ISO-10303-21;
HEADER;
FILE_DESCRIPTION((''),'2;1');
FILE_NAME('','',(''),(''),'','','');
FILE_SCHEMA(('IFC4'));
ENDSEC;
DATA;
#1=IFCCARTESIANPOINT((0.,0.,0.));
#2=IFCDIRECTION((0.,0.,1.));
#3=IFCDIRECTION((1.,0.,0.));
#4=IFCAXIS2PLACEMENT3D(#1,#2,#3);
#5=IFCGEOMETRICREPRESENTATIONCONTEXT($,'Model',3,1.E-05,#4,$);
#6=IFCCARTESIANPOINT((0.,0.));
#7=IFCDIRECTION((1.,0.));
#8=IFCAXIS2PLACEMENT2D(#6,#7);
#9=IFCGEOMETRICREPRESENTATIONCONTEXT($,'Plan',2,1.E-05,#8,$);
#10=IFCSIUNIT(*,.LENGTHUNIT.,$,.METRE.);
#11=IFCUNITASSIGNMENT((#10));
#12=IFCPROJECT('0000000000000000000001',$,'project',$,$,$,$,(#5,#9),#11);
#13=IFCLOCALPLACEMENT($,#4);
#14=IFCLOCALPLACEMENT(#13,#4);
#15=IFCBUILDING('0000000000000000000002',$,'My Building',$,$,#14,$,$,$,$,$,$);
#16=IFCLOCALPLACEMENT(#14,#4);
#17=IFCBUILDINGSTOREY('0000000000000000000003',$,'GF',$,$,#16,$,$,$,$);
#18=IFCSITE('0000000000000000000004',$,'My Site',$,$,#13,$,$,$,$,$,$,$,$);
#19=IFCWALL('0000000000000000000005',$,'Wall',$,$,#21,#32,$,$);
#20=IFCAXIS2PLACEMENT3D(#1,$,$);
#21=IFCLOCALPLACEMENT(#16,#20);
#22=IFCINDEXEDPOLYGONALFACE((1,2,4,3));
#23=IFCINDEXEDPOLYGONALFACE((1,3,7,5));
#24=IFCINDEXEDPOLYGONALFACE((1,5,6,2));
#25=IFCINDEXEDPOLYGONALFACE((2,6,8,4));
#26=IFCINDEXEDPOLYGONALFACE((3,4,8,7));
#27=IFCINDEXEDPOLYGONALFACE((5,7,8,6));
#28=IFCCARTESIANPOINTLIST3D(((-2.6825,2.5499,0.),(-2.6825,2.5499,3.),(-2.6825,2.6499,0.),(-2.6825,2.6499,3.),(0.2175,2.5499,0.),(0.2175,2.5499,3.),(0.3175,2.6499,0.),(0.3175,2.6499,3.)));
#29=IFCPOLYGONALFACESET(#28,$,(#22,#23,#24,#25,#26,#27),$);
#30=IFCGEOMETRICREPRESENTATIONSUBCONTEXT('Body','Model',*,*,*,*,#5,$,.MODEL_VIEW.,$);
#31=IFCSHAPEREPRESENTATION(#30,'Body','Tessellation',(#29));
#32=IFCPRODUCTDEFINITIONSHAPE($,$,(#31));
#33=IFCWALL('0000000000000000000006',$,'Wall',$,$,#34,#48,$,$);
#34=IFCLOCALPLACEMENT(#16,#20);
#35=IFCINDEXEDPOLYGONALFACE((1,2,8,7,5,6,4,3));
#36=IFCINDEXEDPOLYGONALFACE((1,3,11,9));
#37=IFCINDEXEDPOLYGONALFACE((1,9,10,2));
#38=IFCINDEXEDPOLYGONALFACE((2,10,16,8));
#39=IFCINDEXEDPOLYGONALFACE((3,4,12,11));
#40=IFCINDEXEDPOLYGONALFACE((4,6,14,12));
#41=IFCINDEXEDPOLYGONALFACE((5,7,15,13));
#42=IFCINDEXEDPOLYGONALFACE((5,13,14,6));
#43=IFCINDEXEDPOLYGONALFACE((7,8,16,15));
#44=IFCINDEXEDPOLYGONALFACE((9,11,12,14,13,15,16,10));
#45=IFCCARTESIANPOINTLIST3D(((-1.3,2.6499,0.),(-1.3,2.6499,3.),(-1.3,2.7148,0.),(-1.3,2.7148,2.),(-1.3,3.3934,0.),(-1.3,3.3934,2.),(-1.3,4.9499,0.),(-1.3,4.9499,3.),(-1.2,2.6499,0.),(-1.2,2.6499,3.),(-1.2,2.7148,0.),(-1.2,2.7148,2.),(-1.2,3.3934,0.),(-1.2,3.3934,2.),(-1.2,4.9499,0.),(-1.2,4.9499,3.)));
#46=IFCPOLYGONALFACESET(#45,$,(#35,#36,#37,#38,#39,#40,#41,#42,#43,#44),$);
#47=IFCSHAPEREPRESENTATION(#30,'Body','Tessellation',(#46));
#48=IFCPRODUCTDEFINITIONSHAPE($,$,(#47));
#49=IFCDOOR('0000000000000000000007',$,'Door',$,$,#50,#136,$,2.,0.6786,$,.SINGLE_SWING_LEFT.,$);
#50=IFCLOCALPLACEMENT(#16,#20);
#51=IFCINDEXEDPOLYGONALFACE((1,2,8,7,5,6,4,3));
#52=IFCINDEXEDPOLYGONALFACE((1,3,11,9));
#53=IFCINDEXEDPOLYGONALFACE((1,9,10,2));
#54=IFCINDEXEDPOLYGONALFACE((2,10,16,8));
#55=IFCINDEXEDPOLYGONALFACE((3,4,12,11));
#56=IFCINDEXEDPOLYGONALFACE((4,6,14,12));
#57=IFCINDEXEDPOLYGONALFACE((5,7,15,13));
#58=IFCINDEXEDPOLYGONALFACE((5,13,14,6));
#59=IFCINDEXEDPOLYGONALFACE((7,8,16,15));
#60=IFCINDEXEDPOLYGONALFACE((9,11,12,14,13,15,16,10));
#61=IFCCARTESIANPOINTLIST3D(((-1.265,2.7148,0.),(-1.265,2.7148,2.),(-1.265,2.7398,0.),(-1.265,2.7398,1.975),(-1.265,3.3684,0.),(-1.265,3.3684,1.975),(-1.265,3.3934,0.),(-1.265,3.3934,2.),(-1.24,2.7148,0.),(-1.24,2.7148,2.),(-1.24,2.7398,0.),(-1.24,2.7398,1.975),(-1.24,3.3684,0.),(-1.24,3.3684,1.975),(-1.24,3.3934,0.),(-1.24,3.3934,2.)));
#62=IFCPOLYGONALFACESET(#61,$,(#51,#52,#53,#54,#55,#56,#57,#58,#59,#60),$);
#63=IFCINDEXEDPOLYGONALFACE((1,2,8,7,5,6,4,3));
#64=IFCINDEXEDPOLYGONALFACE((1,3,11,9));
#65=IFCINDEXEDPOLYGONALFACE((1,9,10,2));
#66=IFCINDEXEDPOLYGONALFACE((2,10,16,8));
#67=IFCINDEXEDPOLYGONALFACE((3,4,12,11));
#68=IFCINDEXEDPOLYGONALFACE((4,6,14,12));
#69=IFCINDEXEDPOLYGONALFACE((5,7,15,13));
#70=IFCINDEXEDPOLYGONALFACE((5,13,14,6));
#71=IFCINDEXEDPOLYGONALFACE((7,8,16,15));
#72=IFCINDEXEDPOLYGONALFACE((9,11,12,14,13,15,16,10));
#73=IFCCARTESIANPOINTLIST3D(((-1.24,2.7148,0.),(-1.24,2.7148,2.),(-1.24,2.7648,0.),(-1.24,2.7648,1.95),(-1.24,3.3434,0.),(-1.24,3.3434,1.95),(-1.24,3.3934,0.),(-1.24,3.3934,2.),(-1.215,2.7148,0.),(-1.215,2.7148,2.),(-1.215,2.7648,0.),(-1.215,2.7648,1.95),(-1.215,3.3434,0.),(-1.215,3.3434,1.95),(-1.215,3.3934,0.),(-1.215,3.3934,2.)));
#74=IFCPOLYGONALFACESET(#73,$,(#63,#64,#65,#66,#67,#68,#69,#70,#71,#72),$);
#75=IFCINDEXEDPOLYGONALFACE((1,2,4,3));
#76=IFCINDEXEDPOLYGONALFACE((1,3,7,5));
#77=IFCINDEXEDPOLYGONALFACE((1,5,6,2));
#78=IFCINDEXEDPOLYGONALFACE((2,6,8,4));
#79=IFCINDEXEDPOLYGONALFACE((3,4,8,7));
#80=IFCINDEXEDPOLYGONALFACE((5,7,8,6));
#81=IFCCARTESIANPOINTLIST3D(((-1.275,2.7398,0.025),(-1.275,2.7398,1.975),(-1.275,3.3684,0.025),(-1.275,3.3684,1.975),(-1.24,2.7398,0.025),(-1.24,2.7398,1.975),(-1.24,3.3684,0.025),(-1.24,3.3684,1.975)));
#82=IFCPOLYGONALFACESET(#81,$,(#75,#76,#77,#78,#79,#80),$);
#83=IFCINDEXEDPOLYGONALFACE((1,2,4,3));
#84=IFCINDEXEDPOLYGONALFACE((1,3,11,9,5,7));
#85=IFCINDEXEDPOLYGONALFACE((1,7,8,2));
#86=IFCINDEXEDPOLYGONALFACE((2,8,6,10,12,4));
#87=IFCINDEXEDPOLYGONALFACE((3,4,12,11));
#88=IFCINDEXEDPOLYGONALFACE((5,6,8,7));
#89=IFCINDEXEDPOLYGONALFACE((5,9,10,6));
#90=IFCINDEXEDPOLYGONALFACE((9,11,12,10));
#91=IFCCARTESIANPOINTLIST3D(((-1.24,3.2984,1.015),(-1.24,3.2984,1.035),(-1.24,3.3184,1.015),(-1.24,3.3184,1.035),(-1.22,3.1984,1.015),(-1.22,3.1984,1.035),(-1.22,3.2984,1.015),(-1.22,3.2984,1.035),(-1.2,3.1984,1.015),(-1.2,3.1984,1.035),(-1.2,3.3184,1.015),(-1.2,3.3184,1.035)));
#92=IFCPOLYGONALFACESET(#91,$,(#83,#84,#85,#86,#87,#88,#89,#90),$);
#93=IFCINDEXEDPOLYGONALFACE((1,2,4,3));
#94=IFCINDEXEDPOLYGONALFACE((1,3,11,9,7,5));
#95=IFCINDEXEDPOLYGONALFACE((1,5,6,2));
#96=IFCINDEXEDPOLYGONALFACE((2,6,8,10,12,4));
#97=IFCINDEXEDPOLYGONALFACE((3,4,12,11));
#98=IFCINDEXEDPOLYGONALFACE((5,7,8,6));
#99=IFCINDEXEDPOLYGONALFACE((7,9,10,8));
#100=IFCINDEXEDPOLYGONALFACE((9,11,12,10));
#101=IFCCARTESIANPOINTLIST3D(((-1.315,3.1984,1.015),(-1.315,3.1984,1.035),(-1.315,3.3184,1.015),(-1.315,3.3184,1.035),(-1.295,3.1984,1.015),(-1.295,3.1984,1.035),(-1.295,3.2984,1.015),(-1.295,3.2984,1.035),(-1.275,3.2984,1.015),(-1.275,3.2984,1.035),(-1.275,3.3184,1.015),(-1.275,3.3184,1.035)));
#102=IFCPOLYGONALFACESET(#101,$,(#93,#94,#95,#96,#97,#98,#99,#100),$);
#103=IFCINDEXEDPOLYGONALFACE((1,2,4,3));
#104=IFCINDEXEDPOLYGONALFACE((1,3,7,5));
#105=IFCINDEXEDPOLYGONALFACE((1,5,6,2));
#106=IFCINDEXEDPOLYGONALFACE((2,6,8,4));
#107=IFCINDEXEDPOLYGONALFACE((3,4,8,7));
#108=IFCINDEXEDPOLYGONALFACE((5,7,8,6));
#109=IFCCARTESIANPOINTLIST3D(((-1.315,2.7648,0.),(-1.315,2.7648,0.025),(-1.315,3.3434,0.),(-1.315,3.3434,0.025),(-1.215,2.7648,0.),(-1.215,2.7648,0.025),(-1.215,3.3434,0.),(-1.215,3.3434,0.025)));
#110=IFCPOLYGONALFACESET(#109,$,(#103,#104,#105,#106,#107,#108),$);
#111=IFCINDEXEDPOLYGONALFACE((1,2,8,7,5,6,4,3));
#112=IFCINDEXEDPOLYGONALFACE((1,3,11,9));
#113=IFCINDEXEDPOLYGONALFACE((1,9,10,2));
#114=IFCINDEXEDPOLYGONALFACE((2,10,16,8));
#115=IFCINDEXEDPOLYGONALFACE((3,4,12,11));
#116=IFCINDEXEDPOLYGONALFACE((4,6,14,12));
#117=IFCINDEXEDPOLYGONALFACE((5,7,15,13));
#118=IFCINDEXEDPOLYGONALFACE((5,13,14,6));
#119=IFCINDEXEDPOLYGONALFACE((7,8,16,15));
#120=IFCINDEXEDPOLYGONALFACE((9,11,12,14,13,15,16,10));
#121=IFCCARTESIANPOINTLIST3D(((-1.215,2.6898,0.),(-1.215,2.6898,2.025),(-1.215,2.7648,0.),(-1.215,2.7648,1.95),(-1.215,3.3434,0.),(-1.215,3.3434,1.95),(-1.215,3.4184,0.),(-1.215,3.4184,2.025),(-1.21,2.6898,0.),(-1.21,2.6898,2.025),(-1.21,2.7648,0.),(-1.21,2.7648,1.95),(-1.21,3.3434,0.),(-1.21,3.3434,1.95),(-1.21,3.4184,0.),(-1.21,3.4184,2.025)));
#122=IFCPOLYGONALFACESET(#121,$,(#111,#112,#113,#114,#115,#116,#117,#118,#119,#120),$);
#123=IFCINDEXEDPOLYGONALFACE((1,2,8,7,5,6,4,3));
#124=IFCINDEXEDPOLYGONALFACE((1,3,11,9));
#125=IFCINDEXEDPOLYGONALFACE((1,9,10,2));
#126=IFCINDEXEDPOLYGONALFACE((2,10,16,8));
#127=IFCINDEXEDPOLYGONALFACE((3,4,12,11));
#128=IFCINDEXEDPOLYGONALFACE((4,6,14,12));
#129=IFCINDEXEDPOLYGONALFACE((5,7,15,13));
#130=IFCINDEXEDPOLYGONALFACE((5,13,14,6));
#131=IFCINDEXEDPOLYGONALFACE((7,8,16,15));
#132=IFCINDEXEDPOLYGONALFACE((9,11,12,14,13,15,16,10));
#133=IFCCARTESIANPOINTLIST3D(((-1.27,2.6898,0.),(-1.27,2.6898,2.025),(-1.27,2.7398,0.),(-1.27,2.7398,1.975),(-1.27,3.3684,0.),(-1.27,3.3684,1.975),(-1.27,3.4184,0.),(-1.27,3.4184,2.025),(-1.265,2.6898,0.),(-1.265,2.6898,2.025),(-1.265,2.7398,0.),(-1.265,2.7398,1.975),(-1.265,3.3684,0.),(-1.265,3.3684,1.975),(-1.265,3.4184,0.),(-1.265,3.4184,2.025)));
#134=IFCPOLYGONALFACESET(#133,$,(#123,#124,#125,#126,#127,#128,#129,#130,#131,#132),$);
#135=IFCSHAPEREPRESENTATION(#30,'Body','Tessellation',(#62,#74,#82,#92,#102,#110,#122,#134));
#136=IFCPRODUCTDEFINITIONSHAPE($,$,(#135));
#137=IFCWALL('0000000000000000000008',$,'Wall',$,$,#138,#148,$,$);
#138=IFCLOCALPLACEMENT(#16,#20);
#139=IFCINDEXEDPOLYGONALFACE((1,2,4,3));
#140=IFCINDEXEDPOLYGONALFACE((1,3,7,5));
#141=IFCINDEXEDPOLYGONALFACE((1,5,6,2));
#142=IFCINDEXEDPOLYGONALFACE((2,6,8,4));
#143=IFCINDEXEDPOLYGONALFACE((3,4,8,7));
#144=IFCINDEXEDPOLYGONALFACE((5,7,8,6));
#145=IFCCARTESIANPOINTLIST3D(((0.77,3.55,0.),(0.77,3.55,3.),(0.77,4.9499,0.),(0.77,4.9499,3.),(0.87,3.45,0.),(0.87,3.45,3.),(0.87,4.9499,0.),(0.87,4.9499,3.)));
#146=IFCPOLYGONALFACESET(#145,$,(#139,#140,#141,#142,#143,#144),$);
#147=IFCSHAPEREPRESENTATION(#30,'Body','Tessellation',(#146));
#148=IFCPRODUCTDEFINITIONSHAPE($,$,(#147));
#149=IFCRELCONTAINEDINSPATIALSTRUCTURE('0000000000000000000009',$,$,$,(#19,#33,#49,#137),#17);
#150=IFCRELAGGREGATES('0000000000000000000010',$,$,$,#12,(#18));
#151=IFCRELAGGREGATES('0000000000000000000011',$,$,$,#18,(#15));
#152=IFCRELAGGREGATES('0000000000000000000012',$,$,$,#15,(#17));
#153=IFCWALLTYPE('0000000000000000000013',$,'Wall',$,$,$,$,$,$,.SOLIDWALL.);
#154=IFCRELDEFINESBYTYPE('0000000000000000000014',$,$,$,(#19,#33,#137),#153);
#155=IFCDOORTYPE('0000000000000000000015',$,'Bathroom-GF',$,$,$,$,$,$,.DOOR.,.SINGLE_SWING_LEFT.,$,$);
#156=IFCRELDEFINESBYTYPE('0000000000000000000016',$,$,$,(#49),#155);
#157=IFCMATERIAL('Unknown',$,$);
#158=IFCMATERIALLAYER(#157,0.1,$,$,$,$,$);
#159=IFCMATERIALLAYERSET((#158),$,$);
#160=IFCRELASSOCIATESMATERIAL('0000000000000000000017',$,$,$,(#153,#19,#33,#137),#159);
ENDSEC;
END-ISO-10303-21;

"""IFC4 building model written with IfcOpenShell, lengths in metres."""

from ifc_helpers import new_model, entity, si_unit, frame, origin_with_axes, origin_2d_with_axis, place, context, subcontext, project, spatial, line, indexed_curve, outline, extrude, shape, source, transform, mapped, material, layer, layer_set, layer_usage, type_object, type_shapes, element, fill, save


model = new_model("IFC4")

# Units and contexts
model_context = context("Model", 3, precision=1e-05, world=origin_with_axes())
plan_context = context("Plan", 2, precision=1e-05, world=origin_2d_with_axis())
body_context_1 = subcontext(model_context, "Body", "Model", "MODEL_VIEW")
body_context_2 = subcontext(plan_context, "Body", "Plan", "PLAN_VIEW")
ifc_project = project(units=[si_unit("LENGTHUNIT", "METRE")], contexts=[model_context, plan_context])

# Site, building, storey
site_placement = place(None, origin_with_axes())
site = spatial("IfcSite", under=ifc_project, at=site_placement, Name="My Site")
building_placement = place(site_placement, origin_with_axes())
building = spatial("IfcBuilding", under=site, at=building_placement, Name="My Building")
storey_placement = place(building_placement, origin_with_axes())
storey = spatial("IfcBuildingStorey", under=building, at=storey_placement, Name="GF")

# Shared definitions
ifc_material_1 = material(Name="Unknown")

# Shared definitions
ifc_layer_1 = layer(ifc_material_1, 0.1)
ifc_layer_set_1 = layer_set([ifc_layer_1])
wall_type = type_object("IfcWallType", Name="Wall", PredefinedType="SOLIDWALL", material=ifc_layer_set_1)

# Wall
ifc_layer_usage_1 = layer_usage(ifc_layer_set_1, "AXIS2", "POSITIVE", 0.0)
wall_1_placement = place(storey_placement, frame((0.3175, 2.6499, 0.0), z_axis=(0.0, 0.0, 1.0), x_axis=(-1.0, 0.0, 0.0)))
element("IfcWall", 1, at=wall_1_placement, inside=storey, type_object=wall_type, material=ifc_layer_usage_1, Name="Wall", context=body_context_1, shape_type="SweptSolid", body=[
    extrude(outline(indexed_curve([(0.0, 0.0), (0.1, 0.1), (3.0, 0.1), (3.0, 0.0)], segments=[line(1, 2, 3, 4, 1)])), origin_with_axes(), (0.0, 0.0, 1.0), 3.0),
])

# Wall, opening, door
ifc_layer_usage_2 = layer_usage(ifc_layer_set_1, "AXIS2", "POSITIVE", 0.0)
wall_2_placement = place(storey_placement, frame((-1.2, 2.6499, 0.0), z_axis=(0.0, 0.0, 1.0), x_axis=(0.0, 1.0, 0.0)))
wall_2 = element("IfcWall", 2, at=wall_2_placement, inside=storey, type_object=wall_type, material=ifc_layer_usage_2, Name="Wall", context=body_context_1, shape_type="SweptSolid", body=[
    extrude(outline(indexed_curve([(0.0, 0.0), (0.0, 0.1), (2.3, 0.1), (2.3, 0.0)], segments=[line(1, 2, 3, 4, 1)])), origin_with_axes(), (0.0, 0.0, 1.0), 3.0),
])
shared_shape_1 = source(origin_with_axes(), body_context_1, "Body", "SweptSolid", [
    extrude(outline(indexed_curve([(0.0, 0.0), (0.6786, 0.0), (0.6786, 2.0), (0.0, 2.0)], segments=[line(1, 2, 3, 4, 1)])), frame((0.0, -0.6, 0.0), z_axis=(0.0, -1.0, 0.0), x_axis=(1.0, 0.0, 0.0)), (0.0, 0.0, -1.0), 1.2),
])
opening_1_placement = place(wall_2_placement, frame((0.0649, 0.015, 0.0), z_axis=(0.0, 0.0, 1.0), x_axis=(1.0, 0.0, 0.0)))
opening_1 = element("IfcOpeningElement", 3, at=opening_1_placement, cuts=wall_2, PredefinedType="OPENING", context=body_context_1, shape_type="MappedRepresentation", body=[
    mapped(shared_shape_1, transform((0.0, 0.0, 0.0), x_axis=(1.0, 0.0, 0.0), y_axis=(0.0, 1.0, 0.0), z_axis=(0.0, 0.0, 1.0), scale=1.0)),
])
door_type_1 = type_object("IfcDoorType", Name="Bathroom-GF", OperationType="SINGLE_SWING_LEFT", PredefinedType="DOOR")
shared_shape_2 = source(origin_with_axes(), body_context_1, "Body", "SweptSolid", [
    extrude(outline(indexed_curve([(0.0, 0.0), (0.0, 2.0), (0.6786, 2.0), (0.6786, 0.0), (0.6536, 0.0), (0.6536, 1.975), (0.025, 1.975), (0.025, 0.0)], segments=[line(1, 2, 3, 4, 5, 6, 7, 8, 1)])), frame((0.0, 0.025, 0.0), z_axis=(0.0, -1.0, 0.0), x_axis=(1.0, 0.0, 0.0)), (0.0, 0.0, -1.0), 0.025),
    extrude(outline(indexed_curve([(0.0, 0.0), (0.0, 2.0), (0.6786, 2.0), (0.6786, 0.0), (0.6286, 0.0), (0.6286, 1.95), (0.05, 1.95), (0.05, 0.0)], segments=[line(1, 2, 3, 4, 5, 6, 7, 8, 1)])), frame((0.0, 0.0, 0.0), z_axis=(0.0, -1.0, 0.0), x_axis=(1.0, 0.0, 0.0)), (0.0, 0.0, -1.0), 0.025),
    extrude(outline(indexed_curve([(0.0, 0.0), (0.6286, 0.0), (0.6286, 0.035), (0.0, 0.035)], segments=[line(1, 2, 3, 4, 1)])), frame((0.025, 0.025, 0.025), z_axis=(0.0, 0.0, 1.0), x_axis=(1.0, 0.0, 0.0)), (0.0, 0.0, 1.0), 1.95),
    extrude(outline(indexed_curve([(0.0, 0.0), (0.0, -0.04), (-0.12, -0.04), (-0.12, -0.02), (-0.02, -0.02), (-0.02, 0.0)], segments=[line(1, 2, 3, 4, 5, 6, 1)])), frame((0.6036, 0.025, 1.015), z_axis=(0.0, 0.0, 1.0), x_axis=(1.0, 0.0, 0.0)), (0.0, 0.0, 1.0), 0.02),
    extrude(outline(indexed_curve([(0.0, 0.0), (0.0, 0.04), (-0.12, 0.04), (-0.12, 0.02), (-0.02, 0.02), (-0.02, 0.0)], segments=[line(1, 2, 3, 4, 5, 6, 1)])), frame((0.6036, 0.06, 1.015), z_axis=(0.0, 0.0, 1.0), x_axis=(1.0, 0.0, 0.0)), (0.0, 0.0, 1.0), 0.02),
    extrude(outline(indexed_curve([(0.0, 0.0), (0.5786, 0.0), (0.5786, 0.1), (0.0, 0.1)], segments=[line(1, 2, 3, 4, 1)])), frame((0.05, 0.0, 0.0), z_axis=(0.0, 0.0, 1.0), x_axis=(1.0, 0.0, 0.0)), (0.0, 0.0, 1.0), 0.025),
    extrude(outline(indexed_curve([(0.0, 0.0), (0.0, 2.025), (0.7286, 2.025), (0.7286, 0.0), (0.6536, 0.0), (0.6536, 1.95), (0.075, 1.95), (0.075, 0.0)], segments=[line(1, 2, 3, 4, 5, 6, 7, 8, 1)])), frame((-0.025, -0.005, 0.0), z_axis=(0.0, -1.0, 0.0), x_axis=(1.0, 0.0, 0.0)), (0.0, 0.0, -1.0), 0.005),
    extrude(outline(indexed_curve([(0.0, 0.0), (0.0, 2.025), (0.7286, 2.025), (0.7286, 0.0), (0.6786, 0.0), (0.6786, 1.975), (0.05, 1.975), (0.05, 0.0)], segments=[line(1, 2, 3, 4, 5, 6, 7, 8, 1)])), frame((-0.025, 0.05, 0.0), z_axis=(0.0, -1.0, 0.0), x_axis=(1.0, 0.0, 0.0)), (0.0, 0.0, -1.0), 0.005),
])
shared_shape_3 = source(origin_with_axes(), body_context_2, "Body", "Curve2D", [
    entity("IfcIndexedPolyCurve", entity("IfcCartesianPointList2D", [[0.0, 0.0], [0.0, 0.05], [0.025, 0.05], [0.025, 0.025], [0.05, 0.025], [0.05, 0.0]]), [entity("IfcLineIndex", [1, 2, 3, 4, 5, 6, 1])]),
    entity("IfcIndexedPolyCurve", entity("IfcCartesianPointList2D", [[0.6786, 0.0], [0.6786, 0.05], [0.6536, 0.05], [0.6536, 0.025], [0.6286, 0.025], [0.6286, 0.0]]), [entity("IfcLineIndex", [1, 2, 3, 4, 5, 6, 1])]),
    entity("IfcTrimmedCurve", entity("IfcEllipse", entity("IfcAxis2Placement2D", entity("IfcCartesianPoint", [0.06, 0.05]), entity("IfcDirection", [1.0, 0.0])), 0.5936, 0.6286), [entity("IfcCartesianPoint", [0.6536, 0.05])], [entity("IfcCartesianPoint", [0.06, 0.6786])], True, "CARTESIAN"),
    entity("IfcIndexedPolyCurve", entity("IfcCartesianPointList2D", [[0.025, 0.05], [0.06, 0.05], [0.06, 0.6786], [0.025, 0.6786]]), [entity("IfcLineIndex", [1, 2, 3, 4, 1])]),
])
type_shapes(door_type_1, [shared_shape_2, shared_shape_3])
door_1_placement = place(opening_1_placement, origin_with_axes())
door_1 = element("IfcDoor", 4, at=door_1_placement, inside=storey, type_object=door_type_1, Name="Door", OperationType="SINGLE_SWING_LEFT", OverallHeight=2.0, OverallWidth=0.6786, shapes=[
    shape(body_context_1, "Body", "MappedRepresentation", [mapped(shared_shape_2, transform((0.0, 0.0, 0.0), x_axis=(1.0, 0.0, 0.0), y_axis=(0.0, 1.0, 0.0), z_axis=(0.0, 0.0, 1.0), scale=1.0))]),
    shape(body_context_2, "Body", "MappedRepresentation", [mapped(shared_shape_3, transform((0.0, 0.0, 0.0), x_axis=(1.0, 0.0, 0.0), y_axis=(0.0, 1.0, 0.0), z_axis=(0.0, 0.0, 1.0), scale=1.0))]),
])
fill(opening_1, door_1)

# Wall
ifc_layer_usage_3 = layer_usage(ifc_layer_set_1, "AXIS2", "POSITIVE", 0.0)
wall_3_placement = place(storey_placement, frame((0.77, 5.0499, 0.0), z_axis=(0.0, 0.0, 1.0), x_axis=(0.0, -1.0, 0.0)))
element("IfcWall", 5, at=wall_3_placement, inside=storey, type_object=wall_type, material=ifc_layer_usage_3, Name="Wall", context=body_context_1, shape_type="SweptSolid", body=[
    extrude(outline(indexed_curve([(0.1, 0.0), (0.1, 0.1), (1.5999, 0.1), (1.4999, 0.0)], segments=[line(1, 2, 3, 4, 1)])), origin_with_axes(), (0.0, 0.0, 1.0), 3.0),
])

save(model, "model.ifc")
